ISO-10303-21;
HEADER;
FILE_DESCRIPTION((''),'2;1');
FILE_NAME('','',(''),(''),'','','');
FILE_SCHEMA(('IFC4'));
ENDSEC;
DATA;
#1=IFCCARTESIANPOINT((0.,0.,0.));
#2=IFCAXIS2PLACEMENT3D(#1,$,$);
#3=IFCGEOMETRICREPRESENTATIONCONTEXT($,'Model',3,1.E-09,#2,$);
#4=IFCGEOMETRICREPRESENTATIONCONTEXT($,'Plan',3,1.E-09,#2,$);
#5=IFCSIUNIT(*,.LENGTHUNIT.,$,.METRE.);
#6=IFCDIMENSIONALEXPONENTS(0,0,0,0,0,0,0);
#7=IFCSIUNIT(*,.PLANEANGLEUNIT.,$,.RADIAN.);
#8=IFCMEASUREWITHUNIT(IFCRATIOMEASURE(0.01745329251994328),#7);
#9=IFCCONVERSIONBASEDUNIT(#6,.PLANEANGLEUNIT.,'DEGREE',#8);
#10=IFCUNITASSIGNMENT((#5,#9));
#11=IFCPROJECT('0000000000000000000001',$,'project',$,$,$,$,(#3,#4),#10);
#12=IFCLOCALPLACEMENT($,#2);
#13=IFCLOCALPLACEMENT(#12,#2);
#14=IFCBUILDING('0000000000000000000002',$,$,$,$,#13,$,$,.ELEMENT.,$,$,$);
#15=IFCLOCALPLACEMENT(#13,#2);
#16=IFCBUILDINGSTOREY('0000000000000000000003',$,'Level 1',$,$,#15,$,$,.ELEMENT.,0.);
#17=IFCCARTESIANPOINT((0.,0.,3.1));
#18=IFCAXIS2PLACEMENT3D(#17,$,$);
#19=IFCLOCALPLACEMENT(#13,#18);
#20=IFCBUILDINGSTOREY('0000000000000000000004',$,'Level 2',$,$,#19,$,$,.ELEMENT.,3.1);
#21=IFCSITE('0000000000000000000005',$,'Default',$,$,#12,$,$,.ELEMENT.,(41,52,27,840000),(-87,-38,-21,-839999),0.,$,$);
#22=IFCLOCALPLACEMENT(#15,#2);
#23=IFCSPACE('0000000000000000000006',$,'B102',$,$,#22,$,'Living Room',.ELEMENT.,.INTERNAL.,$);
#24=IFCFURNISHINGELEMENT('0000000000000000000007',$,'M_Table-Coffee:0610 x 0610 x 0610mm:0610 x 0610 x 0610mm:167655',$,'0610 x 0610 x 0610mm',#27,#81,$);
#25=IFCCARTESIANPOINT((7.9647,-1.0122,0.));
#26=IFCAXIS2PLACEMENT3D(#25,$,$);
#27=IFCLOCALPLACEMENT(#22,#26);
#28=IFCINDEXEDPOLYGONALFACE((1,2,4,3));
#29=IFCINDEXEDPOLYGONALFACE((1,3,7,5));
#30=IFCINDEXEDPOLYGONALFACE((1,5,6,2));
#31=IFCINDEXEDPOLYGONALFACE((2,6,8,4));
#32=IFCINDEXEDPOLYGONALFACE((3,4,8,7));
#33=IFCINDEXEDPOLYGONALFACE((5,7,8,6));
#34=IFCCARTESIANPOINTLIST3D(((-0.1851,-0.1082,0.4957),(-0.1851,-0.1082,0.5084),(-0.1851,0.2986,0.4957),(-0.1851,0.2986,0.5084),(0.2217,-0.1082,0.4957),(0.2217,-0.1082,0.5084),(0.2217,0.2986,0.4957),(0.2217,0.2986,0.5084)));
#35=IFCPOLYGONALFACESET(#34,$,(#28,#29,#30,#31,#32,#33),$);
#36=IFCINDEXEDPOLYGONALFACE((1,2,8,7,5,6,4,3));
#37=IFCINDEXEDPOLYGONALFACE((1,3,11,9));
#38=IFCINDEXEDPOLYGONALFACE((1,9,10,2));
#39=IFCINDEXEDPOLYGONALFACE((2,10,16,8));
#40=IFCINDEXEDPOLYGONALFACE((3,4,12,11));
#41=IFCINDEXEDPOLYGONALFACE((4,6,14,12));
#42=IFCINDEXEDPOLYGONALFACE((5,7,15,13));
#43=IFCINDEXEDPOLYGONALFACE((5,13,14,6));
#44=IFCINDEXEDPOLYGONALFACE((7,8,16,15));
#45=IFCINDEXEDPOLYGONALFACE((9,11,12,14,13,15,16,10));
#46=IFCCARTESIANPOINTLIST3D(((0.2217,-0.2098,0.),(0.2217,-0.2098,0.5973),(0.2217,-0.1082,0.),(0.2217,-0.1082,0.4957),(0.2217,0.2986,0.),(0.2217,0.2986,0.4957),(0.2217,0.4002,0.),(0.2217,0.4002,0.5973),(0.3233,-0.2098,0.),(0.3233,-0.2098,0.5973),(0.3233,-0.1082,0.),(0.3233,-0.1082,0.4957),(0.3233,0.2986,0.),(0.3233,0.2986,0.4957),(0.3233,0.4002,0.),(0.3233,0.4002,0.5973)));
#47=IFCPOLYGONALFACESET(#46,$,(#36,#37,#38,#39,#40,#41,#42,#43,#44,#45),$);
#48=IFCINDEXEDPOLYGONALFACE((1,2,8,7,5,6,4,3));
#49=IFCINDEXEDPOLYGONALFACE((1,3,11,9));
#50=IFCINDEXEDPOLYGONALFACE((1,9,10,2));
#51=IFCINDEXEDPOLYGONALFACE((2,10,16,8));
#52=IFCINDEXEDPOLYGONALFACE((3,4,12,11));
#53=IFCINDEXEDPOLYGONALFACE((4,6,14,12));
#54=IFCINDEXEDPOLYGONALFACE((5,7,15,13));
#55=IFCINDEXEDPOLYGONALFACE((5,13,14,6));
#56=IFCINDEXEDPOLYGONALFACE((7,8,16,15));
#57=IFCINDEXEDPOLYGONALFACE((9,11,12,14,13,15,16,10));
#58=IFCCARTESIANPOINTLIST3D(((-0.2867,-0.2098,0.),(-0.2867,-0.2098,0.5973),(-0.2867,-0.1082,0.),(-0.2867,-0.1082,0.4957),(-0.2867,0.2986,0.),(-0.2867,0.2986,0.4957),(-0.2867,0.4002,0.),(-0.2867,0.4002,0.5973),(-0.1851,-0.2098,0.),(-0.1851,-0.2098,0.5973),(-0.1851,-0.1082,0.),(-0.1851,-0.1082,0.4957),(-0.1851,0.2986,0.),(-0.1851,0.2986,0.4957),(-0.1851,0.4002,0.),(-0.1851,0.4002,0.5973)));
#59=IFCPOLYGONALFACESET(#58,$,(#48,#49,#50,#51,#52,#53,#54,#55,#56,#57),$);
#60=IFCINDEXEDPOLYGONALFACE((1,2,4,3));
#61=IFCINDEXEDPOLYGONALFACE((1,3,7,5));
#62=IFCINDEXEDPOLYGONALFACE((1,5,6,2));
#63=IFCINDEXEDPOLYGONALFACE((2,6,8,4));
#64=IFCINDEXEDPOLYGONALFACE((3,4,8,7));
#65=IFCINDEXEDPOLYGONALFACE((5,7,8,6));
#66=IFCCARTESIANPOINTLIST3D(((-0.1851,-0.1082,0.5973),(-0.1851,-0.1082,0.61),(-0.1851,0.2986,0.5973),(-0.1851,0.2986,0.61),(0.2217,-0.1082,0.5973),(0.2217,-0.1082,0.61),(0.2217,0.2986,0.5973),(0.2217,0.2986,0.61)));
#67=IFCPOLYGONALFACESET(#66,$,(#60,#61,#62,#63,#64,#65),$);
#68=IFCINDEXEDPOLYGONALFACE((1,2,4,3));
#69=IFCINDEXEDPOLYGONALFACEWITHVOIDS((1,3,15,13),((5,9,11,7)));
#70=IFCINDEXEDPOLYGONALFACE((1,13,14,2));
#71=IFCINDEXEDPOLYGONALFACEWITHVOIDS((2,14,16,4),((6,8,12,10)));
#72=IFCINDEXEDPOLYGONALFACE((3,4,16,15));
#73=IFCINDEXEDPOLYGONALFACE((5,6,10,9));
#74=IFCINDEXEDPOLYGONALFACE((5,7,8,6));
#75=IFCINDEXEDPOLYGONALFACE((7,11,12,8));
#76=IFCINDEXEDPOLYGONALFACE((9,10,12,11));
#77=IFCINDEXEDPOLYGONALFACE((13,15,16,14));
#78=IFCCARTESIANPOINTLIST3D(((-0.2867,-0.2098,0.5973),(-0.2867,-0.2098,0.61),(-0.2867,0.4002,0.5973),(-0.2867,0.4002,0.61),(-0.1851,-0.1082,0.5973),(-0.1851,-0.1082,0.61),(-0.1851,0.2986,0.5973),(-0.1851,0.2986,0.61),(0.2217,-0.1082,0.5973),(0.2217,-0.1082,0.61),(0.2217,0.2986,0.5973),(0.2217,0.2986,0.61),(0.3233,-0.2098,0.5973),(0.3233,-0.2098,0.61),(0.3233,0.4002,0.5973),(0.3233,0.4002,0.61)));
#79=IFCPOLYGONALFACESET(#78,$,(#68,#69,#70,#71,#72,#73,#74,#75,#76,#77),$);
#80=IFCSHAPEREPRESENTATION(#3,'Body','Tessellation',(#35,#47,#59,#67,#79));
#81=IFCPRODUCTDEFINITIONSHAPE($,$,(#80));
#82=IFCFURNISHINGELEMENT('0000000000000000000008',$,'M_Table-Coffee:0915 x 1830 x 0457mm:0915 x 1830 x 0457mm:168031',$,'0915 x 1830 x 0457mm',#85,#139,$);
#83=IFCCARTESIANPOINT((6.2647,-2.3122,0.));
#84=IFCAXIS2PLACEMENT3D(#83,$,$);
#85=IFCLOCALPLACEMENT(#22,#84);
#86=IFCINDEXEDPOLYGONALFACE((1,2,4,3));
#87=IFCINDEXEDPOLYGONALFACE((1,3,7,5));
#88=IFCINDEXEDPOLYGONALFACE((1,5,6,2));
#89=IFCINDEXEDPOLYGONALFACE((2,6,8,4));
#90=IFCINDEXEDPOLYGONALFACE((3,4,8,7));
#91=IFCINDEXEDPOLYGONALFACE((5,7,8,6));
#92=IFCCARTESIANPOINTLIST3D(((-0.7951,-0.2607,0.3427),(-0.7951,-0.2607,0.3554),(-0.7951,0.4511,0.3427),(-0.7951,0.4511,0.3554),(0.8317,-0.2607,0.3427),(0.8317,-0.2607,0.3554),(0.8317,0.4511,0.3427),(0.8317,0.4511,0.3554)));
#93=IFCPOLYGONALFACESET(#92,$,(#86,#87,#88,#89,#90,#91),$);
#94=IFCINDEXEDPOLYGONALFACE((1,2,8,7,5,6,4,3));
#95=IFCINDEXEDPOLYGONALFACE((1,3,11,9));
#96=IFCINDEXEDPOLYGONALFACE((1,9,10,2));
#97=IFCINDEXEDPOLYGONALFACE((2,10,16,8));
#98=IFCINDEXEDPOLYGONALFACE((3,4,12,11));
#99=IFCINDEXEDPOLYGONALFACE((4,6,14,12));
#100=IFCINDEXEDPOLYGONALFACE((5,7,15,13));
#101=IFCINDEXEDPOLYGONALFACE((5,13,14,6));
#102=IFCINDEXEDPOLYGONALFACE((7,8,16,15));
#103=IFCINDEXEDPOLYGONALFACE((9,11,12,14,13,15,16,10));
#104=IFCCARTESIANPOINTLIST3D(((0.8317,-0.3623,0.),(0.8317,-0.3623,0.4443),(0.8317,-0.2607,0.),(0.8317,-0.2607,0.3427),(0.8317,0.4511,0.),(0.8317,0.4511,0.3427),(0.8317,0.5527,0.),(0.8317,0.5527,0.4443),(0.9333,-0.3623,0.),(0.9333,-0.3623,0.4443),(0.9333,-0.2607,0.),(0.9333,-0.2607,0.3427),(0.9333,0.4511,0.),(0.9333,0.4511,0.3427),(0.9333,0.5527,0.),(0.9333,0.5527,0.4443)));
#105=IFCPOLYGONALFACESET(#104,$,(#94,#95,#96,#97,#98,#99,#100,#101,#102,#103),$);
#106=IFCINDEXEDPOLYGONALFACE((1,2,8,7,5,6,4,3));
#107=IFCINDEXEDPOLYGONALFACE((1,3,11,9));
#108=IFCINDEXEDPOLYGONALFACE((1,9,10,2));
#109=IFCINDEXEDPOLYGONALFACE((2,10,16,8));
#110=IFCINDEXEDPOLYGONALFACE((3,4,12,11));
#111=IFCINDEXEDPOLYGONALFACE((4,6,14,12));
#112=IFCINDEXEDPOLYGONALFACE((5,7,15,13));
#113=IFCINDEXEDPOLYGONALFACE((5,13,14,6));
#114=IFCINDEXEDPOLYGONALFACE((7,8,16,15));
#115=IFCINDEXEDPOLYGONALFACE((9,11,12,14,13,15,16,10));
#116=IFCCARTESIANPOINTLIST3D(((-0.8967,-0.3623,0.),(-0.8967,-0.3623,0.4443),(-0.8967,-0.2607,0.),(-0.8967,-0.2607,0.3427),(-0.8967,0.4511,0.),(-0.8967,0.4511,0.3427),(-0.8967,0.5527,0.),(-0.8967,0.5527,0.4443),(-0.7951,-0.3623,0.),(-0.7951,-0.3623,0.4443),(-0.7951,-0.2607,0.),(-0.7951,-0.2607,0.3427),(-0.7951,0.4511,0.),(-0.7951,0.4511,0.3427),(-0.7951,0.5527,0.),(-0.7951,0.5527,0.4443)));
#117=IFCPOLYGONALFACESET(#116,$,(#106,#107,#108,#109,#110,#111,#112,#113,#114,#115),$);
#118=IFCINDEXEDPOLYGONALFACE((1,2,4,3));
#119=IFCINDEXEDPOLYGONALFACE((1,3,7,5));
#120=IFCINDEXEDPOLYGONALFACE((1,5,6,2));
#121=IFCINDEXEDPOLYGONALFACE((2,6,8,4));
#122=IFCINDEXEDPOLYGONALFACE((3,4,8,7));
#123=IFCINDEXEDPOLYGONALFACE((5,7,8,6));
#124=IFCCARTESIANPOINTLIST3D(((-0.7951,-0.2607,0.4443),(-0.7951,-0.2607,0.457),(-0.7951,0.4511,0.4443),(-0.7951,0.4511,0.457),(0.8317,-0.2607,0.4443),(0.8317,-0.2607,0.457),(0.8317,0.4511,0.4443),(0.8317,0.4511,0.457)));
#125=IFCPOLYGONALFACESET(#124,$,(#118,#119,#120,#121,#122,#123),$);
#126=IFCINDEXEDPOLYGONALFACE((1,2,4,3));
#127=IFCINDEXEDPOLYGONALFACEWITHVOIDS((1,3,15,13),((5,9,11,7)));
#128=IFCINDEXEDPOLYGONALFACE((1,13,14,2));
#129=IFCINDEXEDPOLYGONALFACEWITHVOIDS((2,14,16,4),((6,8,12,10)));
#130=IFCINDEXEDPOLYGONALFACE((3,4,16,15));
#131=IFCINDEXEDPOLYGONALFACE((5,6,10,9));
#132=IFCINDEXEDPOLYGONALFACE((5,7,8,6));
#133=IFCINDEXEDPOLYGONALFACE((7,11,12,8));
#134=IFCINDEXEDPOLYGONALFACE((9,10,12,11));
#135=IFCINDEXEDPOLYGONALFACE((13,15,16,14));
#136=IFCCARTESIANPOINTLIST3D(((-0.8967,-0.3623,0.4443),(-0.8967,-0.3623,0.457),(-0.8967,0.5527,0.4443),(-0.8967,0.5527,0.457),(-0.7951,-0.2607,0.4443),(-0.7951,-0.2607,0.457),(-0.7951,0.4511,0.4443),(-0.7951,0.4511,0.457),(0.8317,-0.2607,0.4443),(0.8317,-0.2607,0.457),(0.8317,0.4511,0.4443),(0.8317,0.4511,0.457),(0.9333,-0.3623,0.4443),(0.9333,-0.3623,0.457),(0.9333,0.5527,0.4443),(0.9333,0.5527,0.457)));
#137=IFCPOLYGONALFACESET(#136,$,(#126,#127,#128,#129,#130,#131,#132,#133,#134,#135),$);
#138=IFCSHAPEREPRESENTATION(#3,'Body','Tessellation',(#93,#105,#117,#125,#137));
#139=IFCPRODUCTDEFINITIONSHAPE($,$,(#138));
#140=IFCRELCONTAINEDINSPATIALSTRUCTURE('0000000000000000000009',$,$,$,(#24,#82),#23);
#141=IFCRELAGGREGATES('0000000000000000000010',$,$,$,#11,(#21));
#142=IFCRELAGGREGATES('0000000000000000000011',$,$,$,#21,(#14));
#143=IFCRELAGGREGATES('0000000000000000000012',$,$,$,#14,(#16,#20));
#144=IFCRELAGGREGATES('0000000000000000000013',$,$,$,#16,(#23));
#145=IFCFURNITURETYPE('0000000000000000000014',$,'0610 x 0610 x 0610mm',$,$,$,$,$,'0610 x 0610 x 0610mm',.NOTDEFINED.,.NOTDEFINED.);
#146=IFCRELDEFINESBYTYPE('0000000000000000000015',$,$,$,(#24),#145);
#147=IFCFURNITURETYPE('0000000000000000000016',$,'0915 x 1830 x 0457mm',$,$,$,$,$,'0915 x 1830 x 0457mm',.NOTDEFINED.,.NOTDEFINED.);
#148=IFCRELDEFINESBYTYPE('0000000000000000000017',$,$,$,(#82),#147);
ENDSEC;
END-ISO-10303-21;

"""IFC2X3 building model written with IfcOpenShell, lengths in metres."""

from ifc_helpers import new_model, entity, si_unit, converted_unit, frame, origin, origin_2d_with_axis, place, context, project, spatial, polyline, rectangle, outline, extrude, source, transform, mapped, type_object, type_shapes, element, save


model = new_model("IFC2X3")

# Units and contexts
model_context = context("Model", 3, precision=1e-09, world=origin())
plan_context = context("Plan", 3, precision=1e-09, world=origin())
ifc_project = project(units=[si_unit("LENGTHUNIT", "METRE"), converted_unit("PLANEANGLEUNIT", "DEGREE", entity("IfcRatioMeasure", 0.01745329251994328), si_unit("PLANEANGLEUNIT", "RADIAN"), dimensions=[0, 0, 0, 0, 0, 0, 0])], contexts=[model_context, plan_context])

# Site, building, storey
site_placement = place(None, origin())
site = spatial("IfcSite", under=ifc_project, at=site_placement, Name="Default", CompositionType="ELEMENT", RefLatitude=(41, 52, 27, 840000), RefLongitude=(-87, -38, -21, -839999), RefElevation=0.0)
building_placement = place(site_placement, origin())
building = spatial("IfcBuilding", under=site, at=building_placement, CompositionType="ELEMENT")
storey_1_placement = place(building_placement, origin())
storey_1 = spatial("IfcBuildingStorey", under=building, at=storey_1_placement, Name="Level 1", CompositionType="ELEMENT", Elevation=0.0)

# Shared definitions
storey_2_placement = place(building_placement, frame((0.0, 0.0, 3.1)))
storey_2 = spatial("IfcBuildingStorey", under=building, at=storey_2_placement, Name="Level 2", CompositionType="ELEMENT", Elevation=3.1)

# Shared definitions
space_1_placement = place(storey_1_placement, origin())
space_1 = spatial("IfcSpace", under=storey_1, at=space_1_placement, Name="B102", LongName="Living Room", CompositionType="ELEMENT", InteriorOrExteriorSpace="INTERNAL")

# Furnishing elements
furniture_type_1 = type_object("IfcFurnitureType", Name="0610 x 0610 x 0610mm", ElementType="0610 x 0610 x 0610mm", AssemblyPlace="NOTDEFINED")
shared_shape_1 = source(origin(), model_context, "Body", "SweptSolid", [
    extrude(rectangle(XDim=0.4068, YDim=0.4068, at=origin_2d_with_axis()), frame((0.0183, 0.0952, 0.4957), z_axis=(0.0, 0.0, 1.0), x_axis=(-1.0, 0.0, 0.0)), (0.0, 0.0, 1.0), 0.0127),
    extrude(outline(polyline([(-0.2732, -0.305), (0.324, -0.305), (0.324, 0.305), (-0.2732, 0.305), (-0.2732, 0.2034), (0.2225, 0.2034), (0.2225, -0.2034), (-0.2732, -0.2034), (-0.2732, -0.305)])), frame((0.2217, 0.0952, 0.2732), z_axis=(1.0, 0.0, 0.0), x_axis=(0.0, 0.0, 1.0)), (0.0, 0.0, 1.0), 0.1016),
    extrude(outline(polyline([(-0.305, -0.3241), (0.305, -0.3241), (0.305, 0.2733), (0.2034, 0.2733), (0.2034, -0.2224), (-0.2034, -0.2224), (-0.2034, 0.2733), (-0.305, 0.2733), (-0.305, -0.3241)])), frame((-0.2867, 0.0952, 0.2733), z_axis=(1.0, 0.0, 0.0), x_axis=(0.0, -1.0, 0.0)), (0.0, 0.0, 1.0), 0.1016),
    extrude(rectangle(XDim=0.4068, YDim=0.4068, at=origin_2d_with_axis()), frame((0.0183, 0.0952, 0.5973), z_axis=(0.0, 0.0, 1.0), x_axis=(-1.0, 0.0, 0.0)), (0.0, 0.0, 1.0), 0.0127),
    extrude(outline(polyline([(-0.305, -0.305), (0.305, -0.305), (0.305, 0.305), (-0.305, 0.305), (-0.305, -0.305)]), holes=[polyline([(-0.2034, -0.2034), (-0.2034, 0.2034), (0.2034, 0.2034), (0.2034, -0.2034), (-0.2034, -0.2034)])]), frame((0.0183, 0.0952, 0.5973), z_axis=(0.0, 0.0, 1.0), x_axis=(-1.0, 0.0, 0.0)), (0.0, 0.0, 1.0), 0.0127),
])
type_shapes(furniture_type_1, [shared_shape_1])
for number, where, name in (
    (1, (7.9647, -1.0122, 0.0), "M_Table-Coffee:0610 x 0610 x 0610mm:0610 x 0610 x 0610mm:167655"),
):
    element("IfcFurnishingElement", number, at=place(space_1_placement, frame(where)), inside=space_1, type_object=furniture_type_1, Name=name, ObjectType="0610 x 0610 x 0610mm", context=model_context, shape_type="MappedRepresentation", body=[
        mapped(shared_shape_1, transform((0.0, 0.0, 0.0), scale=1.0)),
    ])
furniture_type_2 = type_object("IfcFurnitureType", Name="0915 x 1830 x 0457mm", ElementType="0915 x 1830 x 0457mm", AssemblyPlace="NOTDEFINED")
shared_shape_2 = source(origin(), model_context, "Body", "SweptSolid", [
    extrude(rectangle(XDim=1.6268, YDim=0.7118, at=origin_2d_with_axis()), frame((0.0183, 0.0952, 0.3427), z_axis=(0.0, 0.0, 1.0), x_axis=(-1.0, 0.0, 0.0)), (0.0, 0.0, 1.0), 0.0127),
    extrude(outline(polyline([(-0.1967, -0.4575), (0.2475, -0.4575), (0.2475, 0.4575), (-0.1967, 0.4575), (-0.1967, 0.3559), (0.146, 0.3559), (0.146, -0.3559), (-0.1967, -0.3559), (-0.1967, -0.4575)])), frame((0.8317, 0.0952, 0.1967), z_axis=(1.0, 0.0, 0.0), x_axis=(0.0, 0.0, 1.0)), (0.0, 0.0, 1.0), 0.1016),
    extrude(outline(polyline([(-0.4575, -0.2476), (0.4575, -0.2476), (0.4575, 0.1968), (0.3559, 0.1968), (0.3559, -0.1459), (-0.3559, -0.1459), (-0.3559, 0.1968), (-0.4575, 0.1968), (-0.4575, -0.2476)])), frame((-0.8967, 0.0952, 0.1968), z_axis=(1.0, 0.0, 0.0), x_axis=(0.0, -1.0, 0.0)), (0.0, 0.0, 1.0), 0.1016),
    extrude(rectangle(XDim=1.6268, YDim=0.7118, at=origin_2d_with_axis()), frame((0.0183, 0.0952, 0.4443), z_axis=(0.0, 0.0, 1.0), x_axis=(-1.0, 0.0, 0.0)), (0.0, 0.0, 1.0), 0.0127),
    extrude(outline(polyline([(-0.915, -0.4575), (0.915, -0.4575), (0.915, 0.4575), (-0.915, 0.4575), (-0.915, -0.4575)]), holes=[polyline([(-0.8134, -0.3559), (-0.8134, 0.3559), (0.8134, 0.3559), (0.8134, -0.3559), (-0.8134, -0.3559)])]), frame((0.0183, 0.0952, 0.4443), z_axis=(0.0, 0.0, 1.0), x_axis=(-1.0, 0.0, 0.0)), (0.0, 0.0, 1.0), 0.0127),
])
type_shapes(furniture_type_2, [shared_shape_2])
furnishing_1_placement = place(space_1_placement, frame((6.2647, -2.3122, 0.0)))
element("IfcFurnishingElement", 2, at=furnishing_1_placement, inside=space_1, type_object=furniture_type_2, Name="M_Table-Coffee:0915 x 1830 x 0457mm:0915 x 1830 x 0457mm:168031", ObjectType="0915 x 1830 x 0457mm", context=model_context, shape_type="MappedRepresentation", body=[
    mapped(shared_shape_2, transform((0.0, 0.0, 0.0), scale=1.0)),
])

save(model, "model.ifc")
